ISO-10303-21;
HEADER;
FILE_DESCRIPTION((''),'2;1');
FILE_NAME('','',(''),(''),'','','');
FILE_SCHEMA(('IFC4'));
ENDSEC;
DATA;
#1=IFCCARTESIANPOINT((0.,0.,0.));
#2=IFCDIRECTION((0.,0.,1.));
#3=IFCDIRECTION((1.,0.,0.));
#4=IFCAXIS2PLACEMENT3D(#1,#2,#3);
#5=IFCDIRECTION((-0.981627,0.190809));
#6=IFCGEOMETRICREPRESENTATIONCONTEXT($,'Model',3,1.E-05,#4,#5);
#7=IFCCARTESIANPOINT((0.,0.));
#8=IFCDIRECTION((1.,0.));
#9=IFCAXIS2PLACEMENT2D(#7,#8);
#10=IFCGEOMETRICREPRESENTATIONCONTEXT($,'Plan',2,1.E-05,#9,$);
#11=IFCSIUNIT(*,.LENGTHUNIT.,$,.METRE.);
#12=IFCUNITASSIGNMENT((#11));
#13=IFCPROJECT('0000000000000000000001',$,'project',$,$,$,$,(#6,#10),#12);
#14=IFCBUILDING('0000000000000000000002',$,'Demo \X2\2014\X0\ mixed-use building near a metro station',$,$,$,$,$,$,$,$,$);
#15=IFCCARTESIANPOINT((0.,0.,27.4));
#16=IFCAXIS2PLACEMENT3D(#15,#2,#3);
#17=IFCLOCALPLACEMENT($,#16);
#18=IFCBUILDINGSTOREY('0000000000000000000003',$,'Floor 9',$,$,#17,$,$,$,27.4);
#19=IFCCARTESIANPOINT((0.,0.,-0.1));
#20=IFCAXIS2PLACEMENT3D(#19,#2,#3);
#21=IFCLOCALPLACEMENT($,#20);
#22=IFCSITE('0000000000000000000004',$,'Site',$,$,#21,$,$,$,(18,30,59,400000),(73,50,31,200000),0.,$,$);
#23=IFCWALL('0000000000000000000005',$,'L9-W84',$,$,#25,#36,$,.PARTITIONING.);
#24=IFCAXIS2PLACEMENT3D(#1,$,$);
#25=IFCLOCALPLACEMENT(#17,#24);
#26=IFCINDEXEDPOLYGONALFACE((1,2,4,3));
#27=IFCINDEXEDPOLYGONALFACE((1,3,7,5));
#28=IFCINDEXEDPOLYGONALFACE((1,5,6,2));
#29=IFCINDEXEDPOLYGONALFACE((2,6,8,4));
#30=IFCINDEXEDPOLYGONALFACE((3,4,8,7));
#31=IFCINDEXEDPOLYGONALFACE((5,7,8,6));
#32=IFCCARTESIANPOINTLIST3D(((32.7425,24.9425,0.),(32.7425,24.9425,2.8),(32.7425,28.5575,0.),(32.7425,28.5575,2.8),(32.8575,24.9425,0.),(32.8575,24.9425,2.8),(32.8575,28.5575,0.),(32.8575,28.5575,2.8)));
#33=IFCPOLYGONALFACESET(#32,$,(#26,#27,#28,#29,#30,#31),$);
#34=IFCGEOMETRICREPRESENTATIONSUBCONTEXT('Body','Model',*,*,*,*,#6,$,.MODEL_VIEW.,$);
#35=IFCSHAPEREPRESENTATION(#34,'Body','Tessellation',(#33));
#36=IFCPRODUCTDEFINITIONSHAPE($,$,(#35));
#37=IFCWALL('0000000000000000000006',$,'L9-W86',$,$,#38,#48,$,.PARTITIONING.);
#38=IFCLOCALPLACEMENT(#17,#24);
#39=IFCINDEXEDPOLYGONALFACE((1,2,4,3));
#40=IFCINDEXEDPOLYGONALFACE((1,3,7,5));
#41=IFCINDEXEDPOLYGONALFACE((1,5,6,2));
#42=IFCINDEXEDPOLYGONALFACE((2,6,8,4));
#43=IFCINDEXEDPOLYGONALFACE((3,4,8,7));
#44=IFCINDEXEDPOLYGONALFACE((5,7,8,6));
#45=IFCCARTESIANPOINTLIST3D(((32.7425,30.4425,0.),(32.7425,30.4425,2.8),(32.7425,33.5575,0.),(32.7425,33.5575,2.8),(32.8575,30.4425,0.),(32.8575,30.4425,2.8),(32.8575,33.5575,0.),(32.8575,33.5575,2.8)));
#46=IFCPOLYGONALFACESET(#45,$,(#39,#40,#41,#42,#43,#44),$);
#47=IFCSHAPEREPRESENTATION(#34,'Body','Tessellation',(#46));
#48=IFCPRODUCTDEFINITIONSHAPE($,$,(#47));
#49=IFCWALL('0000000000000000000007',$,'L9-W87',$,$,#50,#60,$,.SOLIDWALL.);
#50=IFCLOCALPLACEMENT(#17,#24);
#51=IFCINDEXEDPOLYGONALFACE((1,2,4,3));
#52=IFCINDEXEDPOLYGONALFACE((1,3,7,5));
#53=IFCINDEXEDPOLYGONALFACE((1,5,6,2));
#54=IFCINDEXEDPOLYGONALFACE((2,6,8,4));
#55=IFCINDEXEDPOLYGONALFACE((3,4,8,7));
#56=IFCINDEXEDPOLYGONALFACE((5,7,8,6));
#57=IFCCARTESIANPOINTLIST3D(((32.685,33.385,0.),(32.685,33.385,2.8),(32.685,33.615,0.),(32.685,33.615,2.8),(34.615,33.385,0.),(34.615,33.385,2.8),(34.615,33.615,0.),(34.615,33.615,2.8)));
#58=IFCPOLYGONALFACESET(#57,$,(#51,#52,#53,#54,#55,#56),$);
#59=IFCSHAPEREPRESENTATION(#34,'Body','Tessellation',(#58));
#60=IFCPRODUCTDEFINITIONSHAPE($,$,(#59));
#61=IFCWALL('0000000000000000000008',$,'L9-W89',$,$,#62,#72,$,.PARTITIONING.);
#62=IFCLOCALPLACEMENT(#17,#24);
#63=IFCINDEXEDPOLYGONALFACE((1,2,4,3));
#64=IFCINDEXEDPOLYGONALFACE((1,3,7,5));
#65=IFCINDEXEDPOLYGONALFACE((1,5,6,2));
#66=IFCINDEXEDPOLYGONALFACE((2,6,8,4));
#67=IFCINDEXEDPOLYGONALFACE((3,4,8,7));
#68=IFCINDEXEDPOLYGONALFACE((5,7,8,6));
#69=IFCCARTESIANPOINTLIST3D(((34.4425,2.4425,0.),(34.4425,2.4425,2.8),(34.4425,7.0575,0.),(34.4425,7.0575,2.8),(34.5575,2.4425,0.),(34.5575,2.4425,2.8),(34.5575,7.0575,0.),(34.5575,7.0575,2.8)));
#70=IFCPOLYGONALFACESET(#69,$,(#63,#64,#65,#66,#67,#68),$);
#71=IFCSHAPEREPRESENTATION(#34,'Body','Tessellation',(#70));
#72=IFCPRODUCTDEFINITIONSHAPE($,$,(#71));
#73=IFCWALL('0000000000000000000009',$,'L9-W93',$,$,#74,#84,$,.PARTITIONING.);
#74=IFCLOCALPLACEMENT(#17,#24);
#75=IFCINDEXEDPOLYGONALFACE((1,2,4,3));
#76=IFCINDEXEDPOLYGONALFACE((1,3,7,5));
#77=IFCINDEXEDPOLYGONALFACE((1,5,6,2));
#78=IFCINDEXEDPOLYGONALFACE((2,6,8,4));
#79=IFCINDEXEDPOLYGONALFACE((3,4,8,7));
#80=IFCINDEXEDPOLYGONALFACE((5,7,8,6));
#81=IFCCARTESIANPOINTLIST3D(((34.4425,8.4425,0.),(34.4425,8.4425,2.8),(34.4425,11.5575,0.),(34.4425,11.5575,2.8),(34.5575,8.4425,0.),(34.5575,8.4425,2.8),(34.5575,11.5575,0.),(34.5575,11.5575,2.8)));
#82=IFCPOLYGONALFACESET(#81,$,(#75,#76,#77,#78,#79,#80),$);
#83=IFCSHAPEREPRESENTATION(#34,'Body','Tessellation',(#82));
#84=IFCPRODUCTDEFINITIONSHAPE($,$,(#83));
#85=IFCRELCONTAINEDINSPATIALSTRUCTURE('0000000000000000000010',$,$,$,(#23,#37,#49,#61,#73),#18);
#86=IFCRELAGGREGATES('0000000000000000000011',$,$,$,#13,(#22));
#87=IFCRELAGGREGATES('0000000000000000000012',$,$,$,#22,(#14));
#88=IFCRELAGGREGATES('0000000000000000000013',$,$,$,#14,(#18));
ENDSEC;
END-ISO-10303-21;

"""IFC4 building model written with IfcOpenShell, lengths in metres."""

from ifc_helpers import new_model, si_unit, direction, frame, origin_with_axes, origin_2d_with_axis, place, context, subcontext, project, spatial, line, indexed_curve, outline, extrude, element, save


model = new_model("IFC4")

# Units and contexts
model_context = context("Model", 3, precision=1e-05, world=origin_with_axes(), true_north=direction((-0.981627, 0.190809)))
plan_context = context("Plan", 2, precision=1e-05, world=origin_2d_with_axis())
body_context = subcontext(model_context, "Body", "Model", "MODEL_VIEW")
ifc_project = project(units=[si_unit("LENGTHUNIT", "METRE")], contexts=[model_context, plan_context])

# Site, building, storey
site_placement = place(None, frame((0.0, 0.0, -0.1), z_axis=(0.0, 0.0, 1.0), x_axis=(1.0, 0.0, 0.0)))
site = spatial("IfcSite", under=ifc_project, at=site_placement, Name="Site", RefLatitude=(18, 30, 59, 400000), RefLongitude=(73, 50, 31, 200000), RefElevation=0.0)
building = spatial("IfcBuilding", under=site, Name="Demo — mixed-use building near a metro station")
storey_placement = place(None, frame((0.0, 0.0, 27.4), z_axis=(0.0, 0.0, 1.0), x_axis=(1.0, 0.0, 0.0)))
storey = spatial("IfcBuildingStorey", under=building, at=storey_placement, Name="Floor 9", Elevation=27.4)

# Wall
wall_1_placement = place(storey_placement, frame((0.0, 0.0, -27.4), z_axis=(0.0, 0.0, 1.0), x_axis=(1.0, 0.0, 0.0)))
element("IfcWall", 1, at=wall_1_placement, inside=storey, Name="L9-W84", PredefinedType="PARTITIONING", context=body_context, shape_type="SweptSolid", body=[
    extrude(outline(indexed_curve([(32.8575, 28.5575), (32.8575, 24.9425), (32.7425, 24.9425), (32.7425, 28.5575)], segments=[line(1, 2, 3, 4, 1)])), frame((0.0, 0.0, 27.4), z_axis=(0.0, 0.0, 1.0), x_axis=(1.0, 0.0, 0.0)), (0.0, 0.0, 1.0), 2.8),
])

# Walls
wall_2_placement = place(storey_placement, frame((0.0, 0.0, -27.4), z_axis=(0.0, 0.0, 1.0), x_axis=(1.0, 0.0, 0.0)))
element("IfcWall", 2, at=wall_2_placement, inside=storey, Name="L9-W86", PredefinedType="PARTITIONING", context=body_context, shape_type="SweptSolid", body=[
    extrude(outline(indexed_curve([(32.8575, 33.5575), (32.8575, 30.4425), (32.7425, 30.4425), (32.7425, 33.5575)], segments=[line(1, 2, 3, 4, 1)])), frame((0.0, 0.0, 27.4), z_axis=(0.0, 0.0, 1.0), x_axis=(1.0, 0.0, 0.0)), (0.0, 0.0, 1.0), 2.8),
])
wall_3_placement = place(storey_placement, frame((0.0, 0.0, -27.4), z_axis=(0.0, 0.0, 1.0), x_axis=(1.0, 0.0, 0.0)))
element("IfcWall", 3, at=wall_3_placement, inside=storey, Name="L9-W87", PredefinedType="SOLIDWALL", context=body_context, shape_type="SweptSolid", body=[
    extrude(outline(indexed_curve([(34.615, 33.385), (32.685, 33.385), (32.685, 33.615), (34.615, 33.615)], segments=[line(1, 2, 3, 4, 1)])), frame((0.0, 0.0, 27.4), z_axis=(0.0, 0.0, 1.0), x_axis=(1.0, 0.0, 0.0)), (0.0, 0.0, 1.0), 2.8),
])

# Wall
wall_4_placement = place(storey_placement, frame((0.0, 0.0, -27.4), z_axis=(0.0, 0.0, 1.0), x_axis=(1.0, 0.0, 0.0)))
element("IfcWall", 4, at=wall_4_placement, inside=storey, Name="L9-W89", PredefinedType="PARTITIONING", context=body_context, shape_type="SweptSolid", body=[
    extrude(outline(indexed_curve([(34.4425, 2.4425), (34.4425, 7.0575), (34.5575, 7.0575), (34.5575, 2.4425)], segments=[line(1, 2, 3, 4, 1)])), frame((0.0, 0.0, 27.4), z_axis=(0.0, 0.0, 1.0), x_axis=(1.0, 0.0, 0.0)), (0.0, 0.0, 1.0), 2.8),
])

# Wall
wall_5_placement = place(storey_placement, frame((0.0, 0.0, -27.4), z_axis=(0.0, 0.0, 1.0), x_axis=(1.0, 0.0, 0.0)))
element("IfcWall", 5, at=wall_5_placement, inside=storey, Name="L9-W93", PredefinedType="PARTITIONING", context=body_context, shape_type="SweptSolid", body=[
    extrude(outline(indexed_curve([(34.4425, 8.4425), (34.4425, 11.5575), (34.5575, 11.5575), (34.5575, 8.4425)], segments=[line(1, 2, 3, 4, 1)])), frame((0.0, 0.0, 27.4), z_axis=(0.0, 0.0, 1.0), x_axis=(1.0, 0.0, 0.0)), (0.0, 0.0, 1.0), 2.8),
])

save(model, "model.ifc")
